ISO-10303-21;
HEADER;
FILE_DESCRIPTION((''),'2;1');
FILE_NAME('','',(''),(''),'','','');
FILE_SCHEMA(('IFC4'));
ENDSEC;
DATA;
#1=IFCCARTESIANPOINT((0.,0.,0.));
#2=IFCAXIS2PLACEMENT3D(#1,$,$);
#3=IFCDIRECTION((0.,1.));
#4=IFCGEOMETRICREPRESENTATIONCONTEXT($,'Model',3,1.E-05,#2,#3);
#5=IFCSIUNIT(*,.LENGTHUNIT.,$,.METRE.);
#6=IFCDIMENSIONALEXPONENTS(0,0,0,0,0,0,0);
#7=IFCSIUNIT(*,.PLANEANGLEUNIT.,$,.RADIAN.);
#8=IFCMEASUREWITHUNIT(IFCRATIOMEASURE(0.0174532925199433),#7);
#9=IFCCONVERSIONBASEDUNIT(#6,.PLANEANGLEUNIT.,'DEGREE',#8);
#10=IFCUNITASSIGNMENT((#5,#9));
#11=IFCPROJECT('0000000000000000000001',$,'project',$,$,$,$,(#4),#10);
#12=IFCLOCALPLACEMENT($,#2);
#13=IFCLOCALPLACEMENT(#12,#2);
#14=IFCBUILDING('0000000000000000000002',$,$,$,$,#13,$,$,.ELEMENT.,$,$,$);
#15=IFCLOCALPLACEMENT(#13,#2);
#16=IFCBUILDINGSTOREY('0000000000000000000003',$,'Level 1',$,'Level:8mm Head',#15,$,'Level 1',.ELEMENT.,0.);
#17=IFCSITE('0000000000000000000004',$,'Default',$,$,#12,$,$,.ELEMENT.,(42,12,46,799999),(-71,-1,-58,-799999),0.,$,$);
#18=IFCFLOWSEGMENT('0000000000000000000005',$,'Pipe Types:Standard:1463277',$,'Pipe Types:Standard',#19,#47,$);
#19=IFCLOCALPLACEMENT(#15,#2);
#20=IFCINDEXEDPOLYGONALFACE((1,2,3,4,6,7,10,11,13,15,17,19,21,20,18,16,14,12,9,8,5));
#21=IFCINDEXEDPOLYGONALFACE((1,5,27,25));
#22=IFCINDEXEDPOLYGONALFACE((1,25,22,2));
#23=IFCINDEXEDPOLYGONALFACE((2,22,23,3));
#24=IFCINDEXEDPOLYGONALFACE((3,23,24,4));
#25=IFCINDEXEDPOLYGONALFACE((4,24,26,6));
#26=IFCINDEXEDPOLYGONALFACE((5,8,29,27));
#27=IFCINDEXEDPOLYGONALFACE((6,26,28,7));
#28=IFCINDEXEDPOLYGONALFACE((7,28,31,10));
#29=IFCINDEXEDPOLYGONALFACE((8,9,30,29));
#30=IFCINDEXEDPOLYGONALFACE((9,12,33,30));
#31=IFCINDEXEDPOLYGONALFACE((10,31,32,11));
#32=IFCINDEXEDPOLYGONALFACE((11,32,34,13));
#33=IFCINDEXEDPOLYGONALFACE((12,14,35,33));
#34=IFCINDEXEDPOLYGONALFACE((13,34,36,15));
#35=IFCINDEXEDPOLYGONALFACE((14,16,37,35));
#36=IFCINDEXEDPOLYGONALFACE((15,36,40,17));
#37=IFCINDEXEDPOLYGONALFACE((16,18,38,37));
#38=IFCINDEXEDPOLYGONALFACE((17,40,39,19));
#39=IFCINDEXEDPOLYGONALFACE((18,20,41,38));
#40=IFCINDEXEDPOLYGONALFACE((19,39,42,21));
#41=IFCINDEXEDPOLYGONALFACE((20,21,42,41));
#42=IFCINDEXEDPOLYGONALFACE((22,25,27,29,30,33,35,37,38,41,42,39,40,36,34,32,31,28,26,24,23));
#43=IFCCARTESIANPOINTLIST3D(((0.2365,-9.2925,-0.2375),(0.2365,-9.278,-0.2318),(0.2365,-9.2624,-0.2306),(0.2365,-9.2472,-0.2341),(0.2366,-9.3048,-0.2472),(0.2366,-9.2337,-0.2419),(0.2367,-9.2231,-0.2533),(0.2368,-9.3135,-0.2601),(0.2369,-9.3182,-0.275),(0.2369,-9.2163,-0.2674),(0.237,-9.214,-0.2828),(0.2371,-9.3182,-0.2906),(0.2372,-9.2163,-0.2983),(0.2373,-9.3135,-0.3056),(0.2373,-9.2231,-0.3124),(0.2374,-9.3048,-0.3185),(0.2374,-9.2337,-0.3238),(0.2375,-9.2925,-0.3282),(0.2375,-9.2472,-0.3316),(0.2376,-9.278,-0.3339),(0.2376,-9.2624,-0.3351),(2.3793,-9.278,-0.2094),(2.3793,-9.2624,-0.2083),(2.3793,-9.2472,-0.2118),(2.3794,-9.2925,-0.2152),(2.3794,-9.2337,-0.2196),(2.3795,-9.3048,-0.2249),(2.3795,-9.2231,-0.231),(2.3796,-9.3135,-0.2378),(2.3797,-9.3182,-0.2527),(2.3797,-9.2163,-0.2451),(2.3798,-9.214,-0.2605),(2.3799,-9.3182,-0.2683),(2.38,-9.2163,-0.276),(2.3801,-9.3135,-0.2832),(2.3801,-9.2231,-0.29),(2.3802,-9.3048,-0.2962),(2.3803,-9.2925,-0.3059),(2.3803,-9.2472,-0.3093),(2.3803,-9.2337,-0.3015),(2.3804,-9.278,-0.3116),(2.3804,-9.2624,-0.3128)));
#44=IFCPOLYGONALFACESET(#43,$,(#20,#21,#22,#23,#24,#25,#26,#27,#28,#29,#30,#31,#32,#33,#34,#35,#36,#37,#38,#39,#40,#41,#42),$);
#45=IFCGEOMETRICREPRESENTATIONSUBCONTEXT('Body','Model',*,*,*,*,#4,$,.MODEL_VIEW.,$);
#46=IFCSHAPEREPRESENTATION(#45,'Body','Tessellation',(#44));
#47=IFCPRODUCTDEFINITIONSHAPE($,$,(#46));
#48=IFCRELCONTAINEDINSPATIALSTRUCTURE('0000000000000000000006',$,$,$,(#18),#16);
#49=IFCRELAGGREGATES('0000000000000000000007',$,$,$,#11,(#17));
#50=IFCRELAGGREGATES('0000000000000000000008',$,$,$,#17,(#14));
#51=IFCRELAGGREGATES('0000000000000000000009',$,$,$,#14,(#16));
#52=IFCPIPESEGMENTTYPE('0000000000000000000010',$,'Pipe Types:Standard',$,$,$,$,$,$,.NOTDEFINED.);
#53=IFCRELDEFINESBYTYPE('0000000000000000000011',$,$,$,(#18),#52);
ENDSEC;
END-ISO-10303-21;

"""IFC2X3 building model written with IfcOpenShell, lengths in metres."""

from ifc_helpers import new_model, entity, si_unit, converted_unit, direction, frame, frame_2d, origin, place, context, subcontext, project, spatial, circle, extrude, type_object, element, save


model = new_model("IFC2X3")

# Units and contexts
model_context = context("Model", 3, precision=1e-05, world=origin(), true_north=direction((0.0, 1.0)))
body_context = subcontext(model_context, "Body", "Model", "MODEL_VIEW")
ifc_project = project(units=[si_unit("LENGTHUNIT", "METRE"), converted_unit("PLANEANGLEUNIT", "DEGREE", entity("IfcRatioMeasure", 0.0174532925199433), si_unit("PLANEANGLEUNIT", "RADIAN"), dimensions=[0, 0, 0, 0, 0, 0, 0])], contexts=[model_context])

# Site, building, storey
site_placement = place(None, origin())
site = spatial("IfcSite", under=ifc_project, at=site_placement, Name="Default", CompositionType="ELEMENT", RefLatitude=(42, 12, 46, 799999), RefLongitude=(-71, -1, -58, -799999), RefElevation=0.0)
building_placement = place(site_placement, origin())
building = spatial("IfcBuilding", under=site, at=building_placement, CompositionType="ELEMENT")
storey_placement = place(building_placement, origin())
storey = spatial("IfcBuildingStorey", under=building, at=storey_placement, Name="Level 1", ObjectType="Level:8mm Head", LongName="Level 1", CompositionType="ELEMENT", Elevation=0.0)

# Flow segment
pipe_segment_type = type_object("IfcPipeSegmentType", Name="Pipe Types:Standard", PredefinedType="NOTDEFINED")
flow_segment_1_placement = place(storey_placement, origin())
element("IfcFlowSegment", 1, at=flow_segment_1_placement, inside=storey, type_object=pipe_segment_type, Name="Pipe Types:Standard:1463277", ObjectType="Pipe Types:Standard", context=body_context, shape_type="SweptSolid", body=[
    extrude(circle(Radius=0.0524, at=frame_2d((0.0, 0.0), x_axis=(1.0, 0.0))), frame((0.237, -9.2664, -0.2828), z_axis=(0.999946, 0.0, 0.010416), x_axis=(0.0, 1.0, 0.0)), (0.0, 0.0, 1.0), 2.1429),
])

save(model, "model.ifc")
